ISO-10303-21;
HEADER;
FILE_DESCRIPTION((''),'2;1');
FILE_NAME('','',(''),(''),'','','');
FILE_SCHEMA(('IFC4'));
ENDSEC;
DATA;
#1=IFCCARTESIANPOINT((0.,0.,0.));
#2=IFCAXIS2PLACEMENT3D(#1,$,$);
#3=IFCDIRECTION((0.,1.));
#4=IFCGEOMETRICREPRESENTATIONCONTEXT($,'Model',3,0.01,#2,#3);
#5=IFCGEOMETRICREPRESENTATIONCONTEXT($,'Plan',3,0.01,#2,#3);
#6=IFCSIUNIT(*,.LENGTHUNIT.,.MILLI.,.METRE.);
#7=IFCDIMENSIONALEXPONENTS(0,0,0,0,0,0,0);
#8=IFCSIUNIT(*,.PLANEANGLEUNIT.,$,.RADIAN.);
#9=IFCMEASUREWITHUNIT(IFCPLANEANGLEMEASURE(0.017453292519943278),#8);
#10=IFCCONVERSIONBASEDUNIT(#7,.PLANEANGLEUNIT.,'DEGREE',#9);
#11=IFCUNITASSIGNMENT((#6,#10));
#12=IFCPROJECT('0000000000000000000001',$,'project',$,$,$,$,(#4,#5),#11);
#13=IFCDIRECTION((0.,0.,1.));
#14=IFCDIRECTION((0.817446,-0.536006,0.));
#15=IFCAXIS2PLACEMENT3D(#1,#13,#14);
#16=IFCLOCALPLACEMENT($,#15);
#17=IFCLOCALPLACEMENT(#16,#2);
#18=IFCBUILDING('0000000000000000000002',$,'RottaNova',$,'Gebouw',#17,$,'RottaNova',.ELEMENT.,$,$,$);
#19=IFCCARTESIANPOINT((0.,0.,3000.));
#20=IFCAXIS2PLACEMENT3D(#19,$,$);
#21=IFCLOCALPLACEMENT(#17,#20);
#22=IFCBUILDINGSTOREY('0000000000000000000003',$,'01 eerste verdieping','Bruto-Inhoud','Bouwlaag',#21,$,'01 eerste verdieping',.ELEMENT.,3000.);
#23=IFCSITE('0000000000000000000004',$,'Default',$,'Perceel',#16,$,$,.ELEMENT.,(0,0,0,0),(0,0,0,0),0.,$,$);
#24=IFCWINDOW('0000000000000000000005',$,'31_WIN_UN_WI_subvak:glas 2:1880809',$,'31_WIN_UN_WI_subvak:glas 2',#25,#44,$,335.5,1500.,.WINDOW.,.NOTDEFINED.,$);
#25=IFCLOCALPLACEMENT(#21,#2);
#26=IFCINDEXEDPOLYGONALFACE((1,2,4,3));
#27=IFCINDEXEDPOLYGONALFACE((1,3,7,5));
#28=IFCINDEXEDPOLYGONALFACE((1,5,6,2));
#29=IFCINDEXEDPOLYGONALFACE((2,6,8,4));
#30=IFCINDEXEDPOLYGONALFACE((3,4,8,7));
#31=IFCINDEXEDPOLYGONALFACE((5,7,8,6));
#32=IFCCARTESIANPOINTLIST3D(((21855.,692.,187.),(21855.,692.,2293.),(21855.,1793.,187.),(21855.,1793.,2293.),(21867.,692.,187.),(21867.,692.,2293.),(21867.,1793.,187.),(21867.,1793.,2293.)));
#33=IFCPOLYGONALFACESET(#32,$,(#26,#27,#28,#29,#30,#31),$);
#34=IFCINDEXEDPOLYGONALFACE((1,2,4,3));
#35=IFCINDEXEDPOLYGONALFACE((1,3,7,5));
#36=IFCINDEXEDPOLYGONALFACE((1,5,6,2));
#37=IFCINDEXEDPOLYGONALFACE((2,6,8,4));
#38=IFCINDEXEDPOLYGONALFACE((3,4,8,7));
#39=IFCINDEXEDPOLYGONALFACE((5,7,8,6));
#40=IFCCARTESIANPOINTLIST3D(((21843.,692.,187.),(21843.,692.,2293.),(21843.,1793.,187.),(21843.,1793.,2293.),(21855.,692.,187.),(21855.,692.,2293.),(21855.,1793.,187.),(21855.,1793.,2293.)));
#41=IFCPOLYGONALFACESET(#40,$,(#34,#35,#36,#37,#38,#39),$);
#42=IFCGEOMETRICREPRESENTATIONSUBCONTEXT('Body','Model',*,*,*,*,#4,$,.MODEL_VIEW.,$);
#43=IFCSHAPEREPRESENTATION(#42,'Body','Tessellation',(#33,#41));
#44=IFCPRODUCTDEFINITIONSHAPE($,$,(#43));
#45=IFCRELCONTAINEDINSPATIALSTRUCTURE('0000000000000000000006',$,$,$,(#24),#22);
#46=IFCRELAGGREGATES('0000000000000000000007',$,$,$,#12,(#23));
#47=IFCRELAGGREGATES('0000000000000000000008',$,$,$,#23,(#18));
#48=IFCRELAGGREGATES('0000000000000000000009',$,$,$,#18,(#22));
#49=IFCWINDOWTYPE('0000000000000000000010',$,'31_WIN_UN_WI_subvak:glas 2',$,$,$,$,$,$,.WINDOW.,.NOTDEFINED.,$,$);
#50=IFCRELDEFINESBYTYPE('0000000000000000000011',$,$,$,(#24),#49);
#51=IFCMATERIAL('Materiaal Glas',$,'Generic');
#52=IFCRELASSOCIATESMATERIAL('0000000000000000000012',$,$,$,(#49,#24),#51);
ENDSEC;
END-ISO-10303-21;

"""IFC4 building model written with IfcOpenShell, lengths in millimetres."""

from ifc_helpers import new_model, entity, si_unit, converted_unit, direction, frame, origin, place, context, subcontext, project, spatial, indexed_curve, outline, extrude, source, transform, mapped, material, type_object, type_shapes, element, save


model = new_model("IFC4")

# Units and contexts
model_context = context("Model", 3, precision=0.01, world=origin(), true_north=direction((0.0, 1.0)))
plan_context = context("Plan", 3, precision=0.01, world=origin(), true_north=direction((0.0, 1.0)))
body_context = subcontext(model_context, "Body", "Model", "MODEL_VIEW")
ifc_project = project(units=[si_unit("LENGTHUNIT", "METRE", prefix="MILLI"), converted_unit("PLANEANGLEUNIT", "DEGREE", entity("IfcPlaneAngleMeasure", 0.017453292519943278), si_unit("PLANEANGLEUNIT", "RADIAN"), dimensions=[0, 0, 0, 0, 0, 0, 0])], contexts=[model_context, plan_context])

# Site, building, storey
site_placement = place(None, frame((0.0, 0.0, 0.0), z_axis=(0.0, 0.0, 1.0), x_axis=(0.817446, -0.536006, 0.0)))
site = spatial("IfcSite", under=ifc_project, at=site_placement, Name="Default", ObjectType="Perceel", CompositionType="ELEMENT", RefLatitude=(0, 0, 0, 0), RefLongitude=(0, 0, 0, 0), RefElevation=0.0)
building_placement = place(site_placement, origin())
building = spatial("IfcBuilding", under=site, at=building_placement, Name="RottaNova", ObjectType="Gebouw", LongName="RottaNova", CompositionType="ELEMENT")
storey_placement = place(building_placement, frame((0.0, 0.0, 3000.0)))
storey = spatial("IfcBuildingStorey", under=building, at=storey_placement, Name="01 eerste verdieping", Description="Bruto-Inhoud", ObjectType="Bouwlaag", LongName="01 eerste verdieping", CompositionType="ELEMENT", Elevation=3000.0)

# Shared definitions
ifc_material_1 = material(Name="Materiaal Glas", Category="Generic")

# Window
window_type = type_object("IfcWindowType", Name="31_WIN_UN_WI_subvak:glas 2", PartitioningType="NOTDEFINED", PredefinedType="WINDOW", material=ifc_material_1)
shared_shape_1 = source(origin(), body_context, "Body", "SweptSolid", [
    extrude(outline(indexed_curve([(-550.5, -6.0), (550.5, -6.0), (550.5, 6.0), (-550.5, 6.0), (-550.5, -6.0)], self_intersect=False)), frame((0.0, -6.0, 0.0)), (0.0, 0.0, 1.0), 2106.0),
    extrude(outline(indexed_curve([(-550.5, -6.0), (550.5, -6.0), (550.5, 6.0), (-550.5, 6.0), (-550.5, -6.0)], self_intersect=False)), frame((0.0, 6.0, 0.0)), (0.0, 0.0, 1.0), 2106.0),
])
type_shapes(window_type, [shared_shape_1])
for number, where, z_axis, x_axis, name in (
    (1, (21855.0, 1242.5, 187.0), (0.0, 0.0, 1.0), (0.0, 1.0, 0.0), "31_WIN_UN_WI_subvak:glas 2:1880809"),
):
    element("IfcWindow", number, at=place(storey_placement, frame(where, z_axis=z_axis, x_axis=x_axis)), inside=storey, type_object=window_type, material=ifc_material_1, Name=name, ObjectType="31_WIN_UN_WI_subvak:glas 2", OverallHeight=335.5, OverallWidth=1500.0, PartitioningType="NOTDEFINED", PredefinedType="WINDOW", context=body_context, shape_type="MappedRepresentation", body=[
        mapped(shared_shape_1, transform((0.0, 0.0, 0.0), scale=1.0)),
    ])

save(model, "model.ifc")
